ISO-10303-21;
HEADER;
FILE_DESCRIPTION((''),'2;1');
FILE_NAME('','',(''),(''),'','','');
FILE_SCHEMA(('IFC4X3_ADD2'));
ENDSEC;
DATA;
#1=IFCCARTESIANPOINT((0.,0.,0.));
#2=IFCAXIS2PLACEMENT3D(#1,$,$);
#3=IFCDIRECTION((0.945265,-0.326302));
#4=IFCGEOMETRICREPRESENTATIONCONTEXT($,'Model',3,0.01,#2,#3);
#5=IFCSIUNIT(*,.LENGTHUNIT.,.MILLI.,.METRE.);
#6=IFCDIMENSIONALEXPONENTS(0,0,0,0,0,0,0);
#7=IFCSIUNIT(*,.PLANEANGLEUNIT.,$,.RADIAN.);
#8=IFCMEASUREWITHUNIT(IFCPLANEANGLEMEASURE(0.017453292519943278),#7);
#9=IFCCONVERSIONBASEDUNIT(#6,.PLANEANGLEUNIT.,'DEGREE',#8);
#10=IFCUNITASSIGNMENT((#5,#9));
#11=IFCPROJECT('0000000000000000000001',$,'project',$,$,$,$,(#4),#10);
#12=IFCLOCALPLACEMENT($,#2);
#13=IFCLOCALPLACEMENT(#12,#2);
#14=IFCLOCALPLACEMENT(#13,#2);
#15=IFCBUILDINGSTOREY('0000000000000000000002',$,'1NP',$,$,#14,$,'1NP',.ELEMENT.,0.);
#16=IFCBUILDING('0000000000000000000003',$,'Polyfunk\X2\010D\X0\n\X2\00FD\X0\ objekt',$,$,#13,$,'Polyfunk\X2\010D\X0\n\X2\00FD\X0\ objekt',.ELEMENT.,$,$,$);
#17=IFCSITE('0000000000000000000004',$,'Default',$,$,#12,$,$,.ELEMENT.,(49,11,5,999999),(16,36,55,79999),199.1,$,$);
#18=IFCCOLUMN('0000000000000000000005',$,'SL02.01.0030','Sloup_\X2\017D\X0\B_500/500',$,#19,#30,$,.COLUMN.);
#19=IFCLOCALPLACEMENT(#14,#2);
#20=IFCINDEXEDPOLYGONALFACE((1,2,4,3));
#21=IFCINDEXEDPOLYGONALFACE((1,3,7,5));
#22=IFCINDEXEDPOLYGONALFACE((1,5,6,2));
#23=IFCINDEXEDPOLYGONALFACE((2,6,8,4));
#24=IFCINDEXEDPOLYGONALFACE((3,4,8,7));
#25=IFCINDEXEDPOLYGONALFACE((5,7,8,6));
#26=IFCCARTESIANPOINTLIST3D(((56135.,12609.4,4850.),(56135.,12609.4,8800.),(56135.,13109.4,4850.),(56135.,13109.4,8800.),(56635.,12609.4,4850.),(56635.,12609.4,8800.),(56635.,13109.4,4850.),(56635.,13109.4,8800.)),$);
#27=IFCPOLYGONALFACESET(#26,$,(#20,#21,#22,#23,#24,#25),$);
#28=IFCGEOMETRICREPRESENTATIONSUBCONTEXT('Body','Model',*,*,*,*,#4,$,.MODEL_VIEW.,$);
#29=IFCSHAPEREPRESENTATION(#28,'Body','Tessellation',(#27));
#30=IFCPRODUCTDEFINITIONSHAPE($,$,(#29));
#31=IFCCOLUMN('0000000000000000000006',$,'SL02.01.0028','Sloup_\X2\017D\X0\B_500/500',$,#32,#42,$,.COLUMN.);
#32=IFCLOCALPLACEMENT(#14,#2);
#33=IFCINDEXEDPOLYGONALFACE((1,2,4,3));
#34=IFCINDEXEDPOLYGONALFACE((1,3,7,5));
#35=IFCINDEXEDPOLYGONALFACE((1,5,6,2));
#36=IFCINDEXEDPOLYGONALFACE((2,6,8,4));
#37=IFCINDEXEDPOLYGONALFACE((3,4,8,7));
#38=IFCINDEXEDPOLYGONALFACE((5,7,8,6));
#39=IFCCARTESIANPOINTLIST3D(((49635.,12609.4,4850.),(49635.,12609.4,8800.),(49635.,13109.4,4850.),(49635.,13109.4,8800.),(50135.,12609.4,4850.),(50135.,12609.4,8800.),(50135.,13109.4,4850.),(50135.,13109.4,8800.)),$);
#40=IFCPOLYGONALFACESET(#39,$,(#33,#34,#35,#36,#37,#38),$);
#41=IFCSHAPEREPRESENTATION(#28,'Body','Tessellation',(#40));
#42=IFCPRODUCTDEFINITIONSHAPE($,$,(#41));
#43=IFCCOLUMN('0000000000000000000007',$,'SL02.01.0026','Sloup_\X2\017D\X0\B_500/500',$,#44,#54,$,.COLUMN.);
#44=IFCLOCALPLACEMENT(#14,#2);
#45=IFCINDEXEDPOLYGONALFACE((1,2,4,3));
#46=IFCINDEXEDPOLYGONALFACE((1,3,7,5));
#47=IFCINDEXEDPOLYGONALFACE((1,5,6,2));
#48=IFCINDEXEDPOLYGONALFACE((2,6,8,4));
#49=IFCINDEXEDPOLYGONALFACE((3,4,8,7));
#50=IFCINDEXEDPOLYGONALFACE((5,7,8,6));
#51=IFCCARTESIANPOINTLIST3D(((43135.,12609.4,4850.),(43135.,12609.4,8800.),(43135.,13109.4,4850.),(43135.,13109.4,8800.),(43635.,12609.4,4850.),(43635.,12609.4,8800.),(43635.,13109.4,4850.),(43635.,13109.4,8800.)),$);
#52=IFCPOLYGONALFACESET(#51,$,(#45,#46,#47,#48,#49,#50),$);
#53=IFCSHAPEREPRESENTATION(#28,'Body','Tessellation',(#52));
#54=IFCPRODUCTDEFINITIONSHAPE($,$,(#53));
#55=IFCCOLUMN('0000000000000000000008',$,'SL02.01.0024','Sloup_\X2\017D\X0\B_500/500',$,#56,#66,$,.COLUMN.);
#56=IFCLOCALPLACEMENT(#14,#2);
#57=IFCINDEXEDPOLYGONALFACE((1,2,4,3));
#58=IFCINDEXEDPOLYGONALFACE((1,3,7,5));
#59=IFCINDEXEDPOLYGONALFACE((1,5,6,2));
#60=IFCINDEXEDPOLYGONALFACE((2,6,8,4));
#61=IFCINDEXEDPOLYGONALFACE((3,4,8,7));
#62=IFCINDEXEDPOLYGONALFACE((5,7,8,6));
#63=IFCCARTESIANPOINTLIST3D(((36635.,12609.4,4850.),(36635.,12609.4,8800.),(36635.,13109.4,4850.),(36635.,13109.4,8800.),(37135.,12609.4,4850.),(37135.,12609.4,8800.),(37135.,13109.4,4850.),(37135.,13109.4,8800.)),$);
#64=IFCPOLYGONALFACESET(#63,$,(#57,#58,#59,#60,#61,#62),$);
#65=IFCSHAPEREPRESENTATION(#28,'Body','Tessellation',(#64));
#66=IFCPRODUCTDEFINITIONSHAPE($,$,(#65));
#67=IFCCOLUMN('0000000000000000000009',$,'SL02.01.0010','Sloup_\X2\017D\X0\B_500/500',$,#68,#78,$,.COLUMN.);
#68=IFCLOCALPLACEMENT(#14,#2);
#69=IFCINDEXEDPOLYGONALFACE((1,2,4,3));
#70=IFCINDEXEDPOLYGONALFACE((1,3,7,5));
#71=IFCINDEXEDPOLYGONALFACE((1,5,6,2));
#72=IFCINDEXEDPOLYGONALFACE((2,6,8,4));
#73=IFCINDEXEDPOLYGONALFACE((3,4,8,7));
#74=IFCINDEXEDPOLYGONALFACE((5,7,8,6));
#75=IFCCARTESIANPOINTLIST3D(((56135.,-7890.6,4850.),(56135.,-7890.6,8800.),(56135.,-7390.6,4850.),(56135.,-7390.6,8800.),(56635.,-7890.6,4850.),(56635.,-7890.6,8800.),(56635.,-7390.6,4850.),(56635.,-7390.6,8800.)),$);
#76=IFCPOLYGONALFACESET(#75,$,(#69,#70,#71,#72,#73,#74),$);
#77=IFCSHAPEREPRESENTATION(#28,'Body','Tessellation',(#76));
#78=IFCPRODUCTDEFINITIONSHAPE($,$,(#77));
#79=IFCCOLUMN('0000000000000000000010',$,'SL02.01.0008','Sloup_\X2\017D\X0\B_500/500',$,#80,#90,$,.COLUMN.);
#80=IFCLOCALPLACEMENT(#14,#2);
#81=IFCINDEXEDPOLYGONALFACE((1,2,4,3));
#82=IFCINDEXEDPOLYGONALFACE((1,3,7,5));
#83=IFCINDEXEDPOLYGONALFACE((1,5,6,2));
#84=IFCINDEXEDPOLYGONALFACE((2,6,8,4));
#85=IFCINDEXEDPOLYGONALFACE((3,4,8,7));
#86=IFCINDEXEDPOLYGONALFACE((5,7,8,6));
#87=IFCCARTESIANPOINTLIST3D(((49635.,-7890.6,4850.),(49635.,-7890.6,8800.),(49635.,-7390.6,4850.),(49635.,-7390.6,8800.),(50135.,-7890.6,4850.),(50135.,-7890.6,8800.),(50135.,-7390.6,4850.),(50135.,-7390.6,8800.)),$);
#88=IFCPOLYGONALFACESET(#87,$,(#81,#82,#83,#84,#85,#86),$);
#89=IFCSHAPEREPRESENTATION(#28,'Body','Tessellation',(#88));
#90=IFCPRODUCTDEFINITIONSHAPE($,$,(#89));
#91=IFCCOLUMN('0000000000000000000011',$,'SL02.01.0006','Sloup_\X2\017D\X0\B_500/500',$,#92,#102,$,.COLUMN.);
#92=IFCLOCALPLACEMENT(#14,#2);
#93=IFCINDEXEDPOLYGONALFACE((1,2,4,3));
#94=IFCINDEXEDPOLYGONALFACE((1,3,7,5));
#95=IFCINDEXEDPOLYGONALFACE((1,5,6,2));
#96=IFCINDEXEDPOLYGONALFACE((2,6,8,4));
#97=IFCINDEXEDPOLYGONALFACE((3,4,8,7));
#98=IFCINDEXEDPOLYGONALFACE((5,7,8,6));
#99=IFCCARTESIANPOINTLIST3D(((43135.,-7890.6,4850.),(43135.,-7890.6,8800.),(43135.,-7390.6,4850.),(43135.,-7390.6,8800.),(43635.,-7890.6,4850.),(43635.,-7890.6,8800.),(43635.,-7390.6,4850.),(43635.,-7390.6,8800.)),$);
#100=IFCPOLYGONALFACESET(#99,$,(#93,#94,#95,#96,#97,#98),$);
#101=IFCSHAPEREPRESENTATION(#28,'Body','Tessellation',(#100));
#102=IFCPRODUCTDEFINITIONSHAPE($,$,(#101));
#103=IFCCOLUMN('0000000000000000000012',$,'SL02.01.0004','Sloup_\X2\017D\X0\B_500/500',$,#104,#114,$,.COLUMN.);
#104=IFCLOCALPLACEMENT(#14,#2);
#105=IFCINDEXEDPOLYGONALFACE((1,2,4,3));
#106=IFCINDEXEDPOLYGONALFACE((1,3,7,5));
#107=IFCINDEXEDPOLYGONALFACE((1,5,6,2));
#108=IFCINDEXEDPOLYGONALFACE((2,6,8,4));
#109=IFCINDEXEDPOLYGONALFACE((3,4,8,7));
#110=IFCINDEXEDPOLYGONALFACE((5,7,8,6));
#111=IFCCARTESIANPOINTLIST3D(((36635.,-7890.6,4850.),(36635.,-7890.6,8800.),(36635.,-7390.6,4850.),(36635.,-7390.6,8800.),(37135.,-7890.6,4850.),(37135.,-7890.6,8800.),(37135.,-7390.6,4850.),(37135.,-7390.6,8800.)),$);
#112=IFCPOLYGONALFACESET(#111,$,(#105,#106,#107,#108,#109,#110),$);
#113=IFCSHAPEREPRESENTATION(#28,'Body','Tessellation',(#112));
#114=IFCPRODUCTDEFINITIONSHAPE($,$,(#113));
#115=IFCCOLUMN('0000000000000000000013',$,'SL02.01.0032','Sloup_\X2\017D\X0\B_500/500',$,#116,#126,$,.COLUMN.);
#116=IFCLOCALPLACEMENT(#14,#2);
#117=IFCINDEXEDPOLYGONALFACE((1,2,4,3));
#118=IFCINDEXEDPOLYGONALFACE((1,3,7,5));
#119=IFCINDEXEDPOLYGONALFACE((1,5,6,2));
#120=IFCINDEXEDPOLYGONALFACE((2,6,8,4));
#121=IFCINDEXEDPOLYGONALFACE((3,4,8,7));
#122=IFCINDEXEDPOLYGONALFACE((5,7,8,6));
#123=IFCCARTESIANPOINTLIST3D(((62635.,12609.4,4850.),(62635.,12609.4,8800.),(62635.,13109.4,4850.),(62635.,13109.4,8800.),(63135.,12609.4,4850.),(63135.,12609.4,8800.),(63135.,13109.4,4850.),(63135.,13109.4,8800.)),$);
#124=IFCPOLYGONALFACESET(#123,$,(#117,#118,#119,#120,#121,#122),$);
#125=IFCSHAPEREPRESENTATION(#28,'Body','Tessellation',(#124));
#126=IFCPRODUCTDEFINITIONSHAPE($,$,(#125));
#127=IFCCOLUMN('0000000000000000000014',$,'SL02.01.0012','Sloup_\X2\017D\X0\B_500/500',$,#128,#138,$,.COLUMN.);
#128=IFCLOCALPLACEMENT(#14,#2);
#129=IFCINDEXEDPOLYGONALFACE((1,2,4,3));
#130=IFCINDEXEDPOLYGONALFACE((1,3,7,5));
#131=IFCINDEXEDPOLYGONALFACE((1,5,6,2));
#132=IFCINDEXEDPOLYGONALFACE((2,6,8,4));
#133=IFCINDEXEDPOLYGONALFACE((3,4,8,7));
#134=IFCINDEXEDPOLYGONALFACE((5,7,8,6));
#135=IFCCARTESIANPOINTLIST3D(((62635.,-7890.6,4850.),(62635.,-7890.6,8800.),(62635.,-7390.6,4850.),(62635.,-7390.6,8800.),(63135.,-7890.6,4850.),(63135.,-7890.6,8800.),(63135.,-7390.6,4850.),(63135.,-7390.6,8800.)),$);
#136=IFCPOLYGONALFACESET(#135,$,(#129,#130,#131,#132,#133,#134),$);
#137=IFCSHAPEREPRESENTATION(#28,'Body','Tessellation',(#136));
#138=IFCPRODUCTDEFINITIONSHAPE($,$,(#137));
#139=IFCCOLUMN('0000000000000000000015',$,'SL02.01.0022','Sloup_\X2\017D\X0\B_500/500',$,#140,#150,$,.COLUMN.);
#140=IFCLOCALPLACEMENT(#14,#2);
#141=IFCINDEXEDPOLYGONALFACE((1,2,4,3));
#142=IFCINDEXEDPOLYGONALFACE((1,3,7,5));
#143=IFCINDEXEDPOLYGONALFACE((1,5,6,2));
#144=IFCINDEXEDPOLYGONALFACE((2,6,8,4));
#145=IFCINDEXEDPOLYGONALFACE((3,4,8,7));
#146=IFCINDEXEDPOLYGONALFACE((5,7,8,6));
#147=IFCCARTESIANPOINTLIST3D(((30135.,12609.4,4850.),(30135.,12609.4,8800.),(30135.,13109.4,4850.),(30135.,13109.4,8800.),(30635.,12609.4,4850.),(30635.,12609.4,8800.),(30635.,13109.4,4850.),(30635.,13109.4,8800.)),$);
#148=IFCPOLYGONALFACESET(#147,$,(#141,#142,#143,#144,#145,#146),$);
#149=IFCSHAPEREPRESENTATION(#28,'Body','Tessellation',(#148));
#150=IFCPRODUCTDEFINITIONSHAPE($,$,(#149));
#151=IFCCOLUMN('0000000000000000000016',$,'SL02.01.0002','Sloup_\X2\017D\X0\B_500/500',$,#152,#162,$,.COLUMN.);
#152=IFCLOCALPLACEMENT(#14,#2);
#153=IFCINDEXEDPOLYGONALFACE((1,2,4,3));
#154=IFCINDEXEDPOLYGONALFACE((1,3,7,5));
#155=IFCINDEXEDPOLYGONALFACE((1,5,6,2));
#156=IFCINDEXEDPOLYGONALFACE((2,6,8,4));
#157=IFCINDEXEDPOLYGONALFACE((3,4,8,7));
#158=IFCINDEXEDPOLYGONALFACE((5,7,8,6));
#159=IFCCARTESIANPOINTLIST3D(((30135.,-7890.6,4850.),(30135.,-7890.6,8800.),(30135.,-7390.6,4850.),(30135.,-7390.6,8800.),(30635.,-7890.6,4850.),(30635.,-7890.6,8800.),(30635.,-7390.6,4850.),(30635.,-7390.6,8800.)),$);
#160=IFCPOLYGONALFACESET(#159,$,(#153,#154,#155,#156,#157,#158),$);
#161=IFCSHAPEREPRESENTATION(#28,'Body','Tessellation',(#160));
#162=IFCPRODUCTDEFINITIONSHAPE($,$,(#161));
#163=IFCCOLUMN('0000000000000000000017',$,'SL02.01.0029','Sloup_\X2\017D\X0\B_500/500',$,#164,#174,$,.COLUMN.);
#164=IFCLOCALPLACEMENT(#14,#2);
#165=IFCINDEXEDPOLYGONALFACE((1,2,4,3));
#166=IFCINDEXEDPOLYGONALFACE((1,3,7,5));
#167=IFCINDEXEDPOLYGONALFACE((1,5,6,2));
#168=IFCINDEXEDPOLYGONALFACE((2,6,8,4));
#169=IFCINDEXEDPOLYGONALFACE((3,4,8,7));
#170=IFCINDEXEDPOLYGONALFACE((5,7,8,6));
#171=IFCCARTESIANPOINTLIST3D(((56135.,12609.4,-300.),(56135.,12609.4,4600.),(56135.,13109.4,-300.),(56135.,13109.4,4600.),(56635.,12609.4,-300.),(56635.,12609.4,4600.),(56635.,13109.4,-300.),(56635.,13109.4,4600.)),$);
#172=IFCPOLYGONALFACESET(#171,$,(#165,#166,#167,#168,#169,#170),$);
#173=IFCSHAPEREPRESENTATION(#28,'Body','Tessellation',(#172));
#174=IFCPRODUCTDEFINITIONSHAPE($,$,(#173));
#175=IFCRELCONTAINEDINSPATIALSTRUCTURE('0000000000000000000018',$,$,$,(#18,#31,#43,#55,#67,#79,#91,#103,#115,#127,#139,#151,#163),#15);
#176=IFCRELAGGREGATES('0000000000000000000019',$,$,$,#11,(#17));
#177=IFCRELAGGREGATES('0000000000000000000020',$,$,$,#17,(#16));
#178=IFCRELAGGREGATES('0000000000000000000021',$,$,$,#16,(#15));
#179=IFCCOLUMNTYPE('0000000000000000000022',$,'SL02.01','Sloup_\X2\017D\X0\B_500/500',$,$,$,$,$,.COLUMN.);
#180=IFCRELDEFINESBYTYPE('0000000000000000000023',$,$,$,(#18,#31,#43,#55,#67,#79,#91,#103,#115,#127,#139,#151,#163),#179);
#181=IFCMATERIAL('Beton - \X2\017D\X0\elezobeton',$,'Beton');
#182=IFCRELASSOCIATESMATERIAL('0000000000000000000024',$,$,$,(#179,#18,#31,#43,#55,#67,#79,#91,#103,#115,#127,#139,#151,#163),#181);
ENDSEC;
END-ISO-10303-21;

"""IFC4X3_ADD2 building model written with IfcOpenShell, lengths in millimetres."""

from ifc_helpers import new_model, entity, si_unit, converted_unit, direction, frame, frame_2d, origin, origin_2d_with_axis, place, context, subcontext, project, spatial, rectangle, extrude, source, transform, mapped, material, material_profile, profile_set, profile_usage, type_object, element, save


model = new_model("IFC4X3_ADD2")

# Units and contexts
model_context = context("Model", 3, precision=0.01, world=origin(), true_north=direction((0.945265, -0.326302)))
body_context = subcontext(model_context, "Body", "Model", "MODEL_VIEW")
ifc_project = project(units=[si_unit("LENGTHUNIT", "METRE", prefix="MILLI"), converted_unit("PLANEANGLEUNIT", "DEGREE", entity("IfcPlaneAngleMeasure", 0.017453292519943278), si_unit("PLANEANGLEUNIT", "RADIAN"), dimensions=[0, 0, 0, 0, 0, 0, 0])], contexts=[model_context])

# Site, building, storey
site_placement = place(None, origin())
site = spatial("IfcSite", under=ifc_project, at=site_placement, Name="Default", CompositionType="ELEMENT", RefLatitude=(49, 11, 5, 999999), RefLongitude=(16, 36, 55, 79999), RefElevation=199.1)
building_placement = place(site_placement, origin())
building = spatial("IfcBuilding", under=site, at=building_placement, Name="Polyfunkčný objekt", LongName="Polyfunkčný objekt", CompositionType="ELEMENT")
storey_placement = place(building_placement, origin())
storey = spatial("IfcBuildingStorey", under=building, at=storey_placement, Name="1NP", LongName="1NP", CompositionType="ELEMENT", Elevation=0.0)

# Columns
ifc_material = material(Name="Beton - Železobeton", Category="Beton")
ifc_material_profile_1 = material_profile(ifc_material, rectangle(XDim=500.0, YDim=500.0, at=frame_2d((0.0, 0.0), x_axis=(1.0, 0.0))), Name="Sloup_ŽB_500/500")
ifc_profile_set_1 = profile_set([ifc_material_profile_1], Name="Sloup_ŽB_500/500")
ifc_profile_usage_1 = profile_usage(ifc_profile_set_1)
column_type_1 = type_object("IfcColumnType", Name="SL02.01", Description="Sloup_ŽB_500/500", PredefinedType="COLUMN", material=ifc_profile_set_1)
shared_shape_1 = source(origin(), body_context, "Body", "SweptSolid", [
    extrude(rectangle(XDim=500.0, YDim=500.0, at=frame_2d((0.0, 0.0), x_axis=(1.0, 0.0))), frame((56385.0, 12859.4, 4850.0)), (0.0, 0.0, 1.0), 3950.0),
])
column_1_placement = place(storey_placement, origin())
element("IfcColumn", 1, at=column_1_placement, inside=storey, type_object=column_type_1, material=ifc_profile_usage_1, Name="SL02.01.0030", Description="Sloup_ŽB_500/500", PredefinedType="COLUMN", context=body_context, shape_type="MappedRepresentation", body=[
    mapped(shared_shape_1, transform((0.0, 0.0, 0.0), scale=1.0)),
])
shared_shape_2 = source(origin(), body_context, "Body", "SweptSolid", [
    extrude(rectangle(XDim=500.0, YDim=500.0, at=origin_2d_with_axis()), frame((49885.0, 12859.4, 4850.0)), (0.0, 0.0, 1.0), 3950.0),
])
column_2_placement = place(storey_placement, origin())
element("IfcColumn", 2, at=column_2_placement, inside=storey, type_object=column_type_1, material=ifc_profile_usage_1, Name="SL02.01.0028", Description="Sloup_ŽB_500/500", PredefinedType="COLUMN", context=body_context, shape_type="MappedRepresentation", body=[
    mapped(shared_shape_2, transform((0.0, 0.0, 0.0), scale=1.0)),
])
shared_shape_3 = source(origin(), body_context, "Body", "SweptSolid", [
    extrude(rectangle(XDim=500.0, YDim=500.0, at=origin_2d_with_axis()), frame((43385.0, 12859.4, 4850.0)), (0.0, 0.0, 1.0), 3950.0),
])
column_3_placement = place(storey_placement, origin())
element("IfcColumn", 3, at=column_3_placement, inside=storey, type_object=column_type_1, material=ifc_profile_usage_1, Name="SL02.01.0026", Description="Sloup_ŽB_500/500", PredefinedType="COLUMN", context=body_context, shape_type="MappedRepresentation", body=[
    mapped(shared_shape_3, transform((0.0, 0.0, 0.0), scale=1.0)),
])
shared_shape_4 = source(origin(), body_context, "Body", "SweptSolid", [
    extrude(rectangle(XDim=500.0, YDim=500.0, at=origin_2d_with_axis()), frame((36885.0, 12859.4, 4850.0), z_axis=(0.0, 0.0, 1.0), x_axis=(0.0, 1.0, 0.0)), (0.0, 0.0, 1.0), 3950.0),
])
column_4_placement = place(storey_placement, origin())
element("IfcColumn", 4, at=column_4_placement, inside=storey, type_object=column_type_1, material=ifc_profile_usage_1, Name="SL02.01.0024", Description="Sloup_ŽB_500/500", PredefinedType="COLUMN", context=body_context, shape_type="MappedRepresentation", body=[
    mapped(shared_shape_4, transform((0.0, 0.0, 0.0), scale=1.0)),
])
shared_shape_5 = source(origin(), body_context, "Body", "SweptSolid", [
    extrude(rectangle(XDim=500.0, YDim=500.0, at=origin_2d_with_axis()), frame((56385.0, -7640.6, 4850.0)), (0.0, 0.0, 1.0), 3950.0),
])
column_5_placement = place(storey_placement, origin())
element("IfcColumn", 5, at=column_5_placement, inside=storey, type_object=column_type_1, material=ifc_profile_usage_1, Name="SL02.01.0010", Description="Sloup_ŽB_500/500", PredefinedType="COLUMN", context=body_context, shape_type="MappedRepresentation", body=[
    mapped(shared_shape_5, transform((0.0, 0.0, 0.0), scale=1.0)),
])
shared_shape_6 = source(origin(), body_context, "Body", "SweptSolid", [
    extrude(rectangle(XDim=500.0, YDim=500.0, at=frame_2d((0.0, 0.0), x_axis=(1.0, 0.0))), frame((49885.0, -7640.6, 4850.0)), (0.0, 0.0, 1.0), 3950.0),
])
column_6_placement = place(storey_placement, origin())
element("IfcColumn", 6, at=column_6_placement, inside=storey, type_object=column_type_1, material=ifc_profile_usage_1, Name="SL02.01.0008", Description="Sloup_ŽB_500/500", PredefinedType="COLUMN", context=body_context, shape_type="MappedRepresentation", body=[
    mapped(shared_shape_6, transform((0.0, 0.0, 0.0), scale=1.0)),
])
shared_shape_7 = source(origin(), body_context, "Body", "SweptSolid", [
    extrude(rectangle(XDim=500.0, YDim=500.0, at=origin_2d_with_axis()), frame((43385.0, -7640.6, 4850.0)), (0.0, 0.0, 1.0), 3950.0),
])
column_7_placement = place(storey_placement, origin())
element("IfcColumn", 7, at=column_7_placement, inside=storey, type_object=column_type_1, material=ifc_profile_usage_1, Name="SL02.01.0006", Description="Sloup_ŽB_500/500", PredefinedType="COLUMN", context=body_context, shape_type="MappedRepresentation", body=[
    mapped(shared_shape_7, transform((0.0, 0.0, 0.0), scale=1.0)),
])
shared_shape_8 = source(origin(), body_context, "Body", "SweptSolid", [
    extrude(rectangle(XDim=500.0, YDim=500.0, at=origin_2d_with_axis()), frame((36885.0, -7640.6, 4850.0)), (0.0, 0.0, 1.0), 3950.0),
])
column_8_placement = place(storey_placement, origin())
element("IfcColumn", 8, at=column_8_placement, inside=storey, type_object=column_type_1, material=ifc_profile_usage_1, Name="SL02.01.0004", Description="Sloup_ŽB_500/500", PredefinedType="COLUMN", context=body_context, shape_type="MappedRepresentation", body=[
    mapped(shared_shape_8, transform((0.0, 0.0, 0.0), scale=1.0)),
])
shared_shape_9 = source(origin(), body_context, "Body", "SweptSolid", [
    extrude(rectangle(XDim=500.0, YDim=500.0, at=origin_2d_with_axis()), frame((62885.0, 12859.4, 4850.0), z_axis=(0.0, 0.0, 1.0), x_axis=(-1.0, 0.0, 0.0)), (0.0, 0.0, 1.0), 3950.0),
])
column_9_placement = place(storey_placement, origin())
element("IfcColumn", 9, at=column_9_placement, inside=storey, type_object=column_type_1, material=ifc_profile_usage_1, Name="SL02.01.0032", Description="Sloup_ŽB_500/500", PredefinedType="COLUMN", context=body_context, shape_type="MappedRepresentation", body=[
    mapped(shared_shape_9, transform((0.0, 0.0, 0.0), scale=1.0)),
])
shared_shape_10 = source(origin(), body_context, "Body", "SweptSolid", [
    extrude(rectangle(XDim=500.0, YDim=500.0, at=frame_2d((0.0, 0.0), x_axis=(1.0, 0.0))), frame((62885.0, -7640.6, 4850.0), z_axis=(0.0, 0.0, 1.0), x_axis=(-1.0, 0.0, 0.0)), (0.0, 0.0, 1.0), 3950.0),
])
column_10_placement = place(storey_placement, origin())
element("IfcColumn", 10, at=column_10_placement, inside=storey, type_object=column_type_1, material=ifc_profile_usage_1, Name="SL02.01.0012", Description="Sloup_ŽB_500/500", PredefinedType="COLUMN", context=body_context, shape_type="MappedRepresentation", body=[
    mapped(shared_shape_10, transform((0.0, 0.0, 0.0), scale=1.0)),
])
shared_shape_11 = source(origin(), body_context, "Body", "SweptSolid", [
    extrude(rectangle(XDim=500.0, YDim=500.0, at=origin_2d_with_axis()), frame((30385.0, 12859.4, 4850.0), z_axis=(0.0, 0.0, 1.0), x_axis=(-1.0, 0.0, 0.0)), (0.0, 0.0, 1.0), 3950.0),
])
column_11_placement = place(storey_placement, origin())
element("IfcColumn", 11, at=column_11_placement, inside=storey, type_object=column_type_1, material=ifc_profile_usage_1, Name="SL02.01.0022", Description="Sloup_ŽB_500/500", PredefinedType="COLUMN", context=body_context, shape_type="MappedRepresentation", body=[
    mapped(shared_shape_11, transform((0.0, 0.0, 0.0), scale=1.0)),
])
shared_shape_12 = source(origin(), body_context, "Body", "SweptSolid", [
    extrude(rectangle(XDim=500.0, YDim=500.0, at=frame_2d((0.0, 0.0), x_axis=(1.0, 0.0))), frame((30385.0, -7640.6, 4850.0), z_axis=(0.0, 0.0, 1.0), x_axis=(-1.0, 0.0, 0.0)), (0.0, 0.0, 1.0), 3950.0),
])
column_12_placement = place(storey_placement, origin())
element("IfcColumn", 12, at=column_12_placement, inside=storey, type_object=column_type_1, material=ifc_profile_usage_1, Name="SL02.01.0002", Description="Sloup_ŽB_500/500", PredefinedType="COLUMN", context=body_context, shape_type="MappedRepresentation", body=[
    mapped(shared_shape_12, transform((0.0, 0.0, 0.0), scale=1.0)),
])
shared_shape_13 = source(origin(), body_context, "Body", "SweptSolid", [
    extrude(rectangle(XDim=500.0, YDim=500.0, at=frame_2d((0.0, 83.3), x_axis=(1.0, 0.0))), frame((56385.0, 12776.1, -300.0)), (0.0, 0.0, 1.0), 4900.0),
])
column_13_placement = place(storey_placement, origin())
element("IfcColumn", 13, at=column_13_placement, inside=storey, type_object=column_type_1, material=ifc_profile_usage_1, Name="SL02.01.0029", Description="Sloup_ŽB_500/500", PredefinedType="COLUMN", context=body_context, shape_type="MappedRepresentation", body=[
    mapped(shared_shape_13, transform((0.0, 0.0, 0.0), scale=1.0)),
])

save(model, "model.ifc")
